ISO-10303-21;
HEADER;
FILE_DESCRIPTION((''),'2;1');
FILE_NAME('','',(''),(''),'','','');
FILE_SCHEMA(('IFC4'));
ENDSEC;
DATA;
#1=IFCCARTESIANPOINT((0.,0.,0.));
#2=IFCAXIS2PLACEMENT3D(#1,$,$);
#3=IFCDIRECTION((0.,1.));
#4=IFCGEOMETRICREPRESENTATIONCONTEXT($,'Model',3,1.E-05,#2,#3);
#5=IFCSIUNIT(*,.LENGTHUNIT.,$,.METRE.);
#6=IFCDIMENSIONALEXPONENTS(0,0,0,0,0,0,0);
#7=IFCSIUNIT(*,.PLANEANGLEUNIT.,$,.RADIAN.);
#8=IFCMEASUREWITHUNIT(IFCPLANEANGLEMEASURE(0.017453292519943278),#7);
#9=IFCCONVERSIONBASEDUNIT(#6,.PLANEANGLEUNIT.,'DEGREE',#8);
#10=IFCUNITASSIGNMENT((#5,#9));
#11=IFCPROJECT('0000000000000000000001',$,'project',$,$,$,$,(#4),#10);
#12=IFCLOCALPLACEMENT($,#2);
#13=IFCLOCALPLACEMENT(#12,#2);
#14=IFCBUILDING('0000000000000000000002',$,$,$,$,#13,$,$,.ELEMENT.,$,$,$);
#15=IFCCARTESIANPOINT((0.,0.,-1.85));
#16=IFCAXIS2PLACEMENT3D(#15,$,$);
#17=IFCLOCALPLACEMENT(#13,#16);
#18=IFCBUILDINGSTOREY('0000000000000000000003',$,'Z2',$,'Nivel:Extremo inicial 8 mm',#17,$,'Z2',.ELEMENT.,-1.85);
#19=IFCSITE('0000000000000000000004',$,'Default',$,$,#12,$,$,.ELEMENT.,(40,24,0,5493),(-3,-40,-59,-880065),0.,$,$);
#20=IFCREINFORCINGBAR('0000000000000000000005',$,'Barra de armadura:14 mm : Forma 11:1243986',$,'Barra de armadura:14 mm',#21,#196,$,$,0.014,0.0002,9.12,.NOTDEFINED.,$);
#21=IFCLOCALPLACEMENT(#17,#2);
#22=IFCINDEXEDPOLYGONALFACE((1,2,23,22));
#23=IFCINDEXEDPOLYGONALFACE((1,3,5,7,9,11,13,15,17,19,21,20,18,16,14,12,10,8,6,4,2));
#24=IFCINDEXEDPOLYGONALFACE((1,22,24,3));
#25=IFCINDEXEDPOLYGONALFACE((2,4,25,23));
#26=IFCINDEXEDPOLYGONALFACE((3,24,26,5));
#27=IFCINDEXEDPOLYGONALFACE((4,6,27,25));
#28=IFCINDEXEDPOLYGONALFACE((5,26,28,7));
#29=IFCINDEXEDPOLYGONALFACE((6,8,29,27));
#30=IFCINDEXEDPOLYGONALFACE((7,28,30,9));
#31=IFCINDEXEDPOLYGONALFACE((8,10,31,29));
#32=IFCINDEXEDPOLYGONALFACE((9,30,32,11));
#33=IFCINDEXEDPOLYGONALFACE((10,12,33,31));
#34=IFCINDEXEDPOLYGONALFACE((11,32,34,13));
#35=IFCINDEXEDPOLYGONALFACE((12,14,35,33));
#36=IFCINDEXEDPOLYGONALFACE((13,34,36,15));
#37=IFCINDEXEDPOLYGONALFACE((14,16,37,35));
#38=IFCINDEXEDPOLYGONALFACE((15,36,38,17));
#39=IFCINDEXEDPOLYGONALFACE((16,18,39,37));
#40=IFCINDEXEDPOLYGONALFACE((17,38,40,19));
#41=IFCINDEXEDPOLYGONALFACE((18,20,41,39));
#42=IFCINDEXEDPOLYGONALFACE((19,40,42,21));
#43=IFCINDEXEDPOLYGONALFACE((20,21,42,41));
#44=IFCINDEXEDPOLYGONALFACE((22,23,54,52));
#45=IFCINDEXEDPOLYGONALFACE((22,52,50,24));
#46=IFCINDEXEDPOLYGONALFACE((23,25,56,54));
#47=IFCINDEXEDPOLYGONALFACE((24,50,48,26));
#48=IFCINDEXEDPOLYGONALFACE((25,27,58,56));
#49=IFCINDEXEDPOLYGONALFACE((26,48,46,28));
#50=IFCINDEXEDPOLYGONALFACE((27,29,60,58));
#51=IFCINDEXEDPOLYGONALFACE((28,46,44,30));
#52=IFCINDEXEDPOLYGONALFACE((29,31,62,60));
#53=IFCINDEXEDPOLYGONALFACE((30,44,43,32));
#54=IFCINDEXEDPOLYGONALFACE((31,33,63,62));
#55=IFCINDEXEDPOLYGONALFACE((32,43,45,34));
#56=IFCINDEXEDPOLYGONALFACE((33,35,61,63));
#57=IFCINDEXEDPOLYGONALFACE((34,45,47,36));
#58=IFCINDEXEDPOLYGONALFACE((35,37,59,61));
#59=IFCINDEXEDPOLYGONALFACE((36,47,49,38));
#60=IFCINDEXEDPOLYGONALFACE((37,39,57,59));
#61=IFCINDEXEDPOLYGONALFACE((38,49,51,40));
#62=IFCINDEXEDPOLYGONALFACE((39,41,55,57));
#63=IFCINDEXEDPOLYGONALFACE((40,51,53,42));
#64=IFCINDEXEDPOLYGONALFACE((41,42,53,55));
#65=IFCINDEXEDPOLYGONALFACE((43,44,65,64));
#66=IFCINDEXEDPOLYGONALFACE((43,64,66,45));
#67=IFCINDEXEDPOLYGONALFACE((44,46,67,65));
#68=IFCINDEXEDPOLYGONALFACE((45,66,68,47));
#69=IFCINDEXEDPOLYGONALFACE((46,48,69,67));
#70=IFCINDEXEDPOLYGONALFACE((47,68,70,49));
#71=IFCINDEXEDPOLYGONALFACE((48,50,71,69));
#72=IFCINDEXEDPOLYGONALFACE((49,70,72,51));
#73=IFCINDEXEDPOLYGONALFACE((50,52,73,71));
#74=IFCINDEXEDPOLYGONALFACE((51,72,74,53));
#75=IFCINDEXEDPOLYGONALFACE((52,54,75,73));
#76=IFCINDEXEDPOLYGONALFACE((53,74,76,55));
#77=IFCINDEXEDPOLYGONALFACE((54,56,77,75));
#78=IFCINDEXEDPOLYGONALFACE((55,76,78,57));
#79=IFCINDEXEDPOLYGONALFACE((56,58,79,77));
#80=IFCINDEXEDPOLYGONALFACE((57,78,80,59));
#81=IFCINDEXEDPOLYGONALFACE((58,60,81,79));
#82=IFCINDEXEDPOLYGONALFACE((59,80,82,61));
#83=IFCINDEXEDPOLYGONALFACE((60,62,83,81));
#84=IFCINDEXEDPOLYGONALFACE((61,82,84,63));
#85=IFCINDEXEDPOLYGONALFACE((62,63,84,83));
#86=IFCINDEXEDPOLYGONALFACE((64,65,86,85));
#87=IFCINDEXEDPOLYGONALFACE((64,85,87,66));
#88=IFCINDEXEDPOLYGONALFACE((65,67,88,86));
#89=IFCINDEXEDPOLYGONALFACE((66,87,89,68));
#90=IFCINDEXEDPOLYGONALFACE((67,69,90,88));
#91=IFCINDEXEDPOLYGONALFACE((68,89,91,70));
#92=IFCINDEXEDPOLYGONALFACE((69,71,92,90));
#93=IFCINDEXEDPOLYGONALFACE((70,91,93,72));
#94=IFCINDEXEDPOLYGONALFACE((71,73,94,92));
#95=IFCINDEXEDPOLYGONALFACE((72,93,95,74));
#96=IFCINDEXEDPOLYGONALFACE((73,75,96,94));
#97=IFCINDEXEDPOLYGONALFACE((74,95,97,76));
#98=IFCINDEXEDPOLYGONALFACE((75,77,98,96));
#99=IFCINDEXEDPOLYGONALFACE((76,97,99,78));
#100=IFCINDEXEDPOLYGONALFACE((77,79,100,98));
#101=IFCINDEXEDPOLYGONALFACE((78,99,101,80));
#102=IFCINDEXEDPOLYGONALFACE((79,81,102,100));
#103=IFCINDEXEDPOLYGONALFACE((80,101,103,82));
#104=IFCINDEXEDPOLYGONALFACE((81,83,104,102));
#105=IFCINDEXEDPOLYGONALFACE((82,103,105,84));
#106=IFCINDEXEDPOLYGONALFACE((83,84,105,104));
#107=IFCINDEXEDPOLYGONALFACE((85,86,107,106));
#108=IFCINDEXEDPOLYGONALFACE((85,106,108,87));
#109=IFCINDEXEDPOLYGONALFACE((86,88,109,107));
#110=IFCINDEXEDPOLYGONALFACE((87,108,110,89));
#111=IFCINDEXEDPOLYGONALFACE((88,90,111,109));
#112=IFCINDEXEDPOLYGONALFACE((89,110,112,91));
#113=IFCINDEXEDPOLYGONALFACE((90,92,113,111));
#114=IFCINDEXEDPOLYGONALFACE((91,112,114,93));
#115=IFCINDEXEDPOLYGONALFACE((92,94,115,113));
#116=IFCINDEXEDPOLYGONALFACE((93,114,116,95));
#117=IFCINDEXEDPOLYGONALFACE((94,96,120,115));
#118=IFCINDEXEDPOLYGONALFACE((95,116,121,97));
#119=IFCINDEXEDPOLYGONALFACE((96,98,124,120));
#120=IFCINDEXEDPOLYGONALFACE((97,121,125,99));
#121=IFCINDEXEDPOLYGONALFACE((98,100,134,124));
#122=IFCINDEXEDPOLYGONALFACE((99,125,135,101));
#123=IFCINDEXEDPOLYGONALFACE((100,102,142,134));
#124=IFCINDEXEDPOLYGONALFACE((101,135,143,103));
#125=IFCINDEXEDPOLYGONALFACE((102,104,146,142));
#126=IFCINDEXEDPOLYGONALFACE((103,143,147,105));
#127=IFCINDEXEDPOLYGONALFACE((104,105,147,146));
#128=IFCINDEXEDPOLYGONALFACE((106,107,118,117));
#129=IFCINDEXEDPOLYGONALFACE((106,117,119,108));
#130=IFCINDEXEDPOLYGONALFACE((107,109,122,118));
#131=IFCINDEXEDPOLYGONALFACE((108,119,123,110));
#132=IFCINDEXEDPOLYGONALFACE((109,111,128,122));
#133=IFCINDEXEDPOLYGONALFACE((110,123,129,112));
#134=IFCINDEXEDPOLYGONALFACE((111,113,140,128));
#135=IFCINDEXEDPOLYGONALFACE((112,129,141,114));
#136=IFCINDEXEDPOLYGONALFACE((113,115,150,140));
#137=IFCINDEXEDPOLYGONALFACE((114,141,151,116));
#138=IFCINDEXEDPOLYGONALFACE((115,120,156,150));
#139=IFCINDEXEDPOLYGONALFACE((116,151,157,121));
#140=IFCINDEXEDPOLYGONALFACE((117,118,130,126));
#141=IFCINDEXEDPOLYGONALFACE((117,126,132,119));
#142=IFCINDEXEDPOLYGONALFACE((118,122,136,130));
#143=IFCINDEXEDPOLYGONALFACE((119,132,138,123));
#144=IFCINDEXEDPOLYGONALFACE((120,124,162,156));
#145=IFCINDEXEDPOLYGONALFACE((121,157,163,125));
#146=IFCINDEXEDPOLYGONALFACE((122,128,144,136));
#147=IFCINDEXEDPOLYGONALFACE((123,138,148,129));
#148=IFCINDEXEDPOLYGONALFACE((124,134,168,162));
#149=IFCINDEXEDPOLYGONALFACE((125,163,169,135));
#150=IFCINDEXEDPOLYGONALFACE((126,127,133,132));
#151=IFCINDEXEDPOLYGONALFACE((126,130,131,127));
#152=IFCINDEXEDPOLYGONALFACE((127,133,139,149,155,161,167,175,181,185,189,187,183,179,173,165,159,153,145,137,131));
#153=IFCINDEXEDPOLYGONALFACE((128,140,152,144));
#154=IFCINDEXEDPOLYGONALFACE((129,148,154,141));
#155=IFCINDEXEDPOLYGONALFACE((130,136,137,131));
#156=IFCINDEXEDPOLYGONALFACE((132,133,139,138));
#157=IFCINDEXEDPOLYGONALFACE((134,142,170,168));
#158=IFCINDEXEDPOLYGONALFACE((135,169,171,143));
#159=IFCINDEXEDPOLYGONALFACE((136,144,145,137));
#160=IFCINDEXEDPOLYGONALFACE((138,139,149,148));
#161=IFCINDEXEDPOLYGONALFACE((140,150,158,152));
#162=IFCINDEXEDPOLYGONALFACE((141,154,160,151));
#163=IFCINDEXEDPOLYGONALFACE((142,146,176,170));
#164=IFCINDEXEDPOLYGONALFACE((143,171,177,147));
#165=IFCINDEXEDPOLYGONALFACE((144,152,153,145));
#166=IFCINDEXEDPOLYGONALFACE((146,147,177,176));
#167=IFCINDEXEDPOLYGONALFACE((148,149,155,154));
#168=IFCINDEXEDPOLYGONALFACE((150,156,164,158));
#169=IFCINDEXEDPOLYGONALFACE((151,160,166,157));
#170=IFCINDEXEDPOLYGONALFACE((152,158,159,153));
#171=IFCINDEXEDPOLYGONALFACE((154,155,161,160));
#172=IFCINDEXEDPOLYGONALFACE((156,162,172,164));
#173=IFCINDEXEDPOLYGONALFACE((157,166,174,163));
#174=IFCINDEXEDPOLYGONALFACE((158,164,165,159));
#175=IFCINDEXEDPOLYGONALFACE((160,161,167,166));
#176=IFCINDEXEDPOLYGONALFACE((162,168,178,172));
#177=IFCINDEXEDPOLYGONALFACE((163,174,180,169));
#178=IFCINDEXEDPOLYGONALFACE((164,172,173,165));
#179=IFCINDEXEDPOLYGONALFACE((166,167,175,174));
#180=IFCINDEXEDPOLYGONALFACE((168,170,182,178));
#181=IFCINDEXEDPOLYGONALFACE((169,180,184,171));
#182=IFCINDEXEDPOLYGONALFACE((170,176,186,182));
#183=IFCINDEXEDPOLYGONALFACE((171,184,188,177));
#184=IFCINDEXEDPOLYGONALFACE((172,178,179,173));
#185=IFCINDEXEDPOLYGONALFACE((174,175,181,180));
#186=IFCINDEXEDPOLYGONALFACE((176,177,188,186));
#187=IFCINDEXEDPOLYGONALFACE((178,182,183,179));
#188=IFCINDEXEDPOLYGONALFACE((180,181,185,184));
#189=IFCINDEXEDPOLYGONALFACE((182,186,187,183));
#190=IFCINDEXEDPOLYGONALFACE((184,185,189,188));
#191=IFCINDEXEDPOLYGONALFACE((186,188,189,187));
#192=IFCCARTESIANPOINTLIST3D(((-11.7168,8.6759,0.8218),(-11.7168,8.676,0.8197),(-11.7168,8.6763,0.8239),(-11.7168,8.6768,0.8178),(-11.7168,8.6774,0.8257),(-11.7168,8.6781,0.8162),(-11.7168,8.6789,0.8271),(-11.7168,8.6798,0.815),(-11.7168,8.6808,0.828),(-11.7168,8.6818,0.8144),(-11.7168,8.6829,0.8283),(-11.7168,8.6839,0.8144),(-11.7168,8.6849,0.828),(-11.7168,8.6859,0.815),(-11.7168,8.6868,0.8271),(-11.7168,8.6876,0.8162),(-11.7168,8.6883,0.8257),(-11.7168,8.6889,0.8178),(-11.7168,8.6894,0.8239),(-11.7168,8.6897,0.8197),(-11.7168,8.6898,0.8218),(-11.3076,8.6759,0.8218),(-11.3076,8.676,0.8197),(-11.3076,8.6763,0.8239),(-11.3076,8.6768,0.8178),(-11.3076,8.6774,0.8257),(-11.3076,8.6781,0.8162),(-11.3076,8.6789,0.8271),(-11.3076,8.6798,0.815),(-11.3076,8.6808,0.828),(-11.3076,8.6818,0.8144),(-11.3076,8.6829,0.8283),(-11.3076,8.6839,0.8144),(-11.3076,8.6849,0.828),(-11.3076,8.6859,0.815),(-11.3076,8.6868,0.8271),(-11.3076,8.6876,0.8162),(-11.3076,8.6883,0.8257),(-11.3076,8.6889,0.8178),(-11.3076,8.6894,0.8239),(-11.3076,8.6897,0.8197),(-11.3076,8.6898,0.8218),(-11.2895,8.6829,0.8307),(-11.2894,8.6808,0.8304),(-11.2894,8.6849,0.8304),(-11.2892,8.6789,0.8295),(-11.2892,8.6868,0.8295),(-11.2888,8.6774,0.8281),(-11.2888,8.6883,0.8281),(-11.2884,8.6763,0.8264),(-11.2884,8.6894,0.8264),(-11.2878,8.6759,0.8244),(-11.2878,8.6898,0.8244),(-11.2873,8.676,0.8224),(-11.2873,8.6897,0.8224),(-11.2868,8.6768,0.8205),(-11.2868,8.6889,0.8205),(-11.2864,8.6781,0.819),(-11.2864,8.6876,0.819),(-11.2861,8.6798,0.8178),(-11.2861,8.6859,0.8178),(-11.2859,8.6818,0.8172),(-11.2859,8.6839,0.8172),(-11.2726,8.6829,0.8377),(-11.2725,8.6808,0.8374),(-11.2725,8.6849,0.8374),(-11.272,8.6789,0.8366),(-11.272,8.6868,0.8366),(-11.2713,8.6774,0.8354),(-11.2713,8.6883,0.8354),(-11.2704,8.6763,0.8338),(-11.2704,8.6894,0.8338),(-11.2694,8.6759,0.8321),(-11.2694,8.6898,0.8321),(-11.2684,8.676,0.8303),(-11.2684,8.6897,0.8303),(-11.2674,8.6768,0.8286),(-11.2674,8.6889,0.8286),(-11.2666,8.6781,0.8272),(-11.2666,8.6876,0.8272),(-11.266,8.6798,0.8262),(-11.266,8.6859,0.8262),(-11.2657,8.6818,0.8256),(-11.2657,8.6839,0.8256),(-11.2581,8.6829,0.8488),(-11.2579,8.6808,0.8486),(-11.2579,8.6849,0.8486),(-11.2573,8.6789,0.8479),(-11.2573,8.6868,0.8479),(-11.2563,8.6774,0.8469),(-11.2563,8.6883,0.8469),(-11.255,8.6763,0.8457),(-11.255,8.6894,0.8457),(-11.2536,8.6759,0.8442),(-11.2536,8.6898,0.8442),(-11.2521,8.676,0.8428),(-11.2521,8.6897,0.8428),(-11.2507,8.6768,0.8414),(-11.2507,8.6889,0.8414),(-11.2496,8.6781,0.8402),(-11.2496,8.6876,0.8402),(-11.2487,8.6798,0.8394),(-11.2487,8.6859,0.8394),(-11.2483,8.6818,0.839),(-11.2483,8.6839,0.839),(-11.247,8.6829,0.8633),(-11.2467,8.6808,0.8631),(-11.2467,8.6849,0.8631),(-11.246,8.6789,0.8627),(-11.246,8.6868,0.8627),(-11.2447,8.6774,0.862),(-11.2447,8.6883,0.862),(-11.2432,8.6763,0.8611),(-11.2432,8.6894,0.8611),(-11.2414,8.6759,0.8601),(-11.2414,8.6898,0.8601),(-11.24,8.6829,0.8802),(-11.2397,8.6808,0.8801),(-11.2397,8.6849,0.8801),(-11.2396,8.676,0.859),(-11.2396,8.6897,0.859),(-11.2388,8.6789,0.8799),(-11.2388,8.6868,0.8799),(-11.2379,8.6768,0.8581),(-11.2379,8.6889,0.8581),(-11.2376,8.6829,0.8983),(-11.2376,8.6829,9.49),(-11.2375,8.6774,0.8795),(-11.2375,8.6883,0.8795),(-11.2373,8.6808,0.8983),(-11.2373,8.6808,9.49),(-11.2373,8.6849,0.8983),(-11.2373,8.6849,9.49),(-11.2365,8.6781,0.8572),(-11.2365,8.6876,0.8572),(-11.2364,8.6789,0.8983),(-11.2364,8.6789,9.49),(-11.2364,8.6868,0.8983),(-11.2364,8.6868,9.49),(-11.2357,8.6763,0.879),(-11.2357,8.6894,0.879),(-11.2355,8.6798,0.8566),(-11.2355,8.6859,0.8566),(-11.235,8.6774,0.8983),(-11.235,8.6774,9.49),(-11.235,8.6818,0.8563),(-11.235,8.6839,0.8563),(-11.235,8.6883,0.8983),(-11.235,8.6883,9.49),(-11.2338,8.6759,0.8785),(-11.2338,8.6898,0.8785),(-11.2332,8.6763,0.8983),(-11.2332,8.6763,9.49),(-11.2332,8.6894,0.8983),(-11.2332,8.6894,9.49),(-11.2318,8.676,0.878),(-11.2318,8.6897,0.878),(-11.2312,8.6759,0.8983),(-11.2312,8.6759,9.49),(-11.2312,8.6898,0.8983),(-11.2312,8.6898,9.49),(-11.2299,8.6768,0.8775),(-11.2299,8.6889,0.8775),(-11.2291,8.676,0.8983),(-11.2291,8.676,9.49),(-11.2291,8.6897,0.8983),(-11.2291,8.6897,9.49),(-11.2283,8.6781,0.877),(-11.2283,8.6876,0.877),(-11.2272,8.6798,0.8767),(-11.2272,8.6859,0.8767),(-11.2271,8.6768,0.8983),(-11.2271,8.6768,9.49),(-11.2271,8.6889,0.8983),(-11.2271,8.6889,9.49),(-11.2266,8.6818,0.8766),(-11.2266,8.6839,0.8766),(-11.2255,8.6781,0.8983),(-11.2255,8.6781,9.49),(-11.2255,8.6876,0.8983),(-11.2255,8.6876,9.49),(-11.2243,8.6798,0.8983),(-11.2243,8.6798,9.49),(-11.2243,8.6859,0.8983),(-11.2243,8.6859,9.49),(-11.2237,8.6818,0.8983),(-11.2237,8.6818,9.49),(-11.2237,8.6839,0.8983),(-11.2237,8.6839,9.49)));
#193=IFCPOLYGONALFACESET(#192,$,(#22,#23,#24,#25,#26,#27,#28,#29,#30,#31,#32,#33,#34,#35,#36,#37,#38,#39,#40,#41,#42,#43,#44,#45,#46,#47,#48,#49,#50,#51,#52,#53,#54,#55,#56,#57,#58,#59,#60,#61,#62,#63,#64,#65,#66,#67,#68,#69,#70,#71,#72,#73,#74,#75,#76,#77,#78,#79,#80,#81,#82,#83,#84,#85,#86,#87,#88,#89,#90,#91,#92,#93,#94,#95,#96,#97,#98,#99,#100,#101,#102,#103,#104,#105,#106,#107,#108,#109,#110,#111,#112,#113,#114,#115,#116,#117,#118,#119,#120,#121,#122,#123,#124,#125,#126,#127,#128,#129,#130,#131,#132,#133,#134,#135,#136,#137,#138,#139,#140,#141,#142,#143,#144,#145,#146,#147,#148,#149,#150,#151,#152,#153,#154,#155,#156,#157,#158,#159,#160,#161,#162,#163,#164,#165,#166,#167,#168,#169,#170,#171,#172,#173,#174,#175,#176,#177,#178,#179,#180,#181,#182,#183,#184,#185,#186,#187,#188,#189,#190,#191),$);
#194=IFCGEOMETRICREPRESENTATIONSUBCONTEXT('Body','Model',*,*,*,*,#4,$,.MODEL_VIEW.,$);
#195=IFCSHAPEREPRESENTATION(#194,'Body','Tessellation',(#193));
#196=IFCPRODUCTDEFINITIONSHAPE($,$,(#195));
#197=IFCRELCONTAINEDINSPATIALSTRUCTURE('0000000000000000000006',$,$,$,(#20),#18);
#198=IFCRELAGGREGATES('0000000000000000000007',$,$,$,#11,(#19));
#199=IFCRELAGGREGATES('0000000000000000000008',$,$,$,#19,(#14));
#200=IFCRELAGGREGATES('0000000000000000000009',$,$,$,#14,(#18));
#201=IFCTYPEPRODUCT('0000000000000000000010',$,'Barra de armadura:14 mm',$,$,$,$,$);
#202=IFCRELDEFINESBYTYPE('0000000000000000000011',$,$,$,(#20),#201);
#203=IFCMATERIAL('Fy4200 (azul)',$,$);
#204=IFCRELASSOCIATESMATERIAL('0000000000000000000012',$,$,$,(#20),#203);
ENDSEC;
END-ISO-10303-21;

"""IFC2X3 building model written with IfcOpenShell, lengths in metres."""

from ifc_helpers import new_model, entity, si_unit, converted_unit, direction, frame, origin, place, context, subcontext, project, spatial, material, type_object, element, save


model = new_model("IFC2X3")

# Units and contexts
model_context = context("Model", 3, precision=1e-05, world=origin(), true_north=direction((0.0, 1.0)))
body_context = subcontext(model_context, "Body", "Model", "MODEL_VIEW")
ifc_project = project(units=[si_unit("LENGTHUNIT", "METRE"), converted_unit("PLANEANGLEUNIT", "DEGREE", entity("IfcPlaneAngleMeasure", 0.017453292519943278), si_unit("PLANEANGLEUNIT", "RADIAN"), dimensions=[0, 0, 0, 0, 0, 0, 0])], contexts=[model_context])

# Site, building, storey
site_placement = place(None, origin())
site = spatial("IfcSite", under=ifc_project, at=site_placement, Name="Default", CompositionType="ELEMENT", RefLatitude=(40, 24, 0, 5493), RefLongitude=(-3, -40, -59, -880065), RefElevation=0.0)
building_placement = place(site_placement, origin())
building = spatial("IfcBuilding", under=site, at=building_placement, CompositionType="ELEMENT")
storey_placement = place(building_placement, frame((0.0, 0.0, -1.85)))
storey = spatial("IfcBuildingStorey", under=building, at=storey_placement, Name="Z2", ObjectType="Nivel:Extremo inicial 8 mm", LongName="Z2", CompositionType="ELEMENT", Elevation=-1.85)

# Reinforcing bar
ifc_material_1 = material(Name="Fy4200 (azul)")
type_product_1 = type_object("IfcTypeProduct", Name="Barra de armadura:14 mm")
reinforcing_bar_1_placement = place(storey_placement, origin())
element("IfcReinforcingBar", 1, at=reinforcing_bar_1_placement, inside=storey, type_object=type_product_1, material=ifc_material_1, Name="Barra de armadura:14 mm : Forma 11:1243986", ObjectType="Barra de armadura:14 mm", BarLength=9.12, BarRole="NOTDEFINED", CrossSectionArea=0.0002, NominalDiameter=0.014, context=body_context, shape_type="AdvancedSweptSolid", body=[
    entity("IfcSweptDiskSolid", entity("IfcCompositeCurve", [entity("IfcCompositeCurveSegment", "CONTINUOUS", True, entity("IfcPolyline", [entity("IfcCartesianPoint", [-11.2306, 8.6829, 9.49]), entity("IfcCartesianPoint", [-11.2306, 8.6829, 0.8983])])), entity("IfcCompositeCurveSegment", "CONTINUOUS", True, entity("IfcTrimmedCurve", entity("IfcCircle", entity("IfcAxis2Placement3D", entity("IfcCartesianPoint", [-11.3076, 8.6829, 0.8983]), entity("IfcDirection", [0.0, 1.0, 0.0]), entity("IfcDirection", [0.0, 0.0, -1.0])), 0.077), [entity("IfcParameterValue", 270.0)], [entity("IfcParameterValue", 360.0)], True, "PARAMETER")), entity("IfcCompositeCurveSegment", "CONTINUOUS", True, entity("IfcPolyline", [entity("IfcCartesianPoint", [-11.3076, 8.6829, 0.8213]), entity("IfcCartesianPoint", [-11.7168, 8.6829, 0.8213])]))], False), 0.007, None, 0.0, 92.0),
])

save(model, "model.ifc")
